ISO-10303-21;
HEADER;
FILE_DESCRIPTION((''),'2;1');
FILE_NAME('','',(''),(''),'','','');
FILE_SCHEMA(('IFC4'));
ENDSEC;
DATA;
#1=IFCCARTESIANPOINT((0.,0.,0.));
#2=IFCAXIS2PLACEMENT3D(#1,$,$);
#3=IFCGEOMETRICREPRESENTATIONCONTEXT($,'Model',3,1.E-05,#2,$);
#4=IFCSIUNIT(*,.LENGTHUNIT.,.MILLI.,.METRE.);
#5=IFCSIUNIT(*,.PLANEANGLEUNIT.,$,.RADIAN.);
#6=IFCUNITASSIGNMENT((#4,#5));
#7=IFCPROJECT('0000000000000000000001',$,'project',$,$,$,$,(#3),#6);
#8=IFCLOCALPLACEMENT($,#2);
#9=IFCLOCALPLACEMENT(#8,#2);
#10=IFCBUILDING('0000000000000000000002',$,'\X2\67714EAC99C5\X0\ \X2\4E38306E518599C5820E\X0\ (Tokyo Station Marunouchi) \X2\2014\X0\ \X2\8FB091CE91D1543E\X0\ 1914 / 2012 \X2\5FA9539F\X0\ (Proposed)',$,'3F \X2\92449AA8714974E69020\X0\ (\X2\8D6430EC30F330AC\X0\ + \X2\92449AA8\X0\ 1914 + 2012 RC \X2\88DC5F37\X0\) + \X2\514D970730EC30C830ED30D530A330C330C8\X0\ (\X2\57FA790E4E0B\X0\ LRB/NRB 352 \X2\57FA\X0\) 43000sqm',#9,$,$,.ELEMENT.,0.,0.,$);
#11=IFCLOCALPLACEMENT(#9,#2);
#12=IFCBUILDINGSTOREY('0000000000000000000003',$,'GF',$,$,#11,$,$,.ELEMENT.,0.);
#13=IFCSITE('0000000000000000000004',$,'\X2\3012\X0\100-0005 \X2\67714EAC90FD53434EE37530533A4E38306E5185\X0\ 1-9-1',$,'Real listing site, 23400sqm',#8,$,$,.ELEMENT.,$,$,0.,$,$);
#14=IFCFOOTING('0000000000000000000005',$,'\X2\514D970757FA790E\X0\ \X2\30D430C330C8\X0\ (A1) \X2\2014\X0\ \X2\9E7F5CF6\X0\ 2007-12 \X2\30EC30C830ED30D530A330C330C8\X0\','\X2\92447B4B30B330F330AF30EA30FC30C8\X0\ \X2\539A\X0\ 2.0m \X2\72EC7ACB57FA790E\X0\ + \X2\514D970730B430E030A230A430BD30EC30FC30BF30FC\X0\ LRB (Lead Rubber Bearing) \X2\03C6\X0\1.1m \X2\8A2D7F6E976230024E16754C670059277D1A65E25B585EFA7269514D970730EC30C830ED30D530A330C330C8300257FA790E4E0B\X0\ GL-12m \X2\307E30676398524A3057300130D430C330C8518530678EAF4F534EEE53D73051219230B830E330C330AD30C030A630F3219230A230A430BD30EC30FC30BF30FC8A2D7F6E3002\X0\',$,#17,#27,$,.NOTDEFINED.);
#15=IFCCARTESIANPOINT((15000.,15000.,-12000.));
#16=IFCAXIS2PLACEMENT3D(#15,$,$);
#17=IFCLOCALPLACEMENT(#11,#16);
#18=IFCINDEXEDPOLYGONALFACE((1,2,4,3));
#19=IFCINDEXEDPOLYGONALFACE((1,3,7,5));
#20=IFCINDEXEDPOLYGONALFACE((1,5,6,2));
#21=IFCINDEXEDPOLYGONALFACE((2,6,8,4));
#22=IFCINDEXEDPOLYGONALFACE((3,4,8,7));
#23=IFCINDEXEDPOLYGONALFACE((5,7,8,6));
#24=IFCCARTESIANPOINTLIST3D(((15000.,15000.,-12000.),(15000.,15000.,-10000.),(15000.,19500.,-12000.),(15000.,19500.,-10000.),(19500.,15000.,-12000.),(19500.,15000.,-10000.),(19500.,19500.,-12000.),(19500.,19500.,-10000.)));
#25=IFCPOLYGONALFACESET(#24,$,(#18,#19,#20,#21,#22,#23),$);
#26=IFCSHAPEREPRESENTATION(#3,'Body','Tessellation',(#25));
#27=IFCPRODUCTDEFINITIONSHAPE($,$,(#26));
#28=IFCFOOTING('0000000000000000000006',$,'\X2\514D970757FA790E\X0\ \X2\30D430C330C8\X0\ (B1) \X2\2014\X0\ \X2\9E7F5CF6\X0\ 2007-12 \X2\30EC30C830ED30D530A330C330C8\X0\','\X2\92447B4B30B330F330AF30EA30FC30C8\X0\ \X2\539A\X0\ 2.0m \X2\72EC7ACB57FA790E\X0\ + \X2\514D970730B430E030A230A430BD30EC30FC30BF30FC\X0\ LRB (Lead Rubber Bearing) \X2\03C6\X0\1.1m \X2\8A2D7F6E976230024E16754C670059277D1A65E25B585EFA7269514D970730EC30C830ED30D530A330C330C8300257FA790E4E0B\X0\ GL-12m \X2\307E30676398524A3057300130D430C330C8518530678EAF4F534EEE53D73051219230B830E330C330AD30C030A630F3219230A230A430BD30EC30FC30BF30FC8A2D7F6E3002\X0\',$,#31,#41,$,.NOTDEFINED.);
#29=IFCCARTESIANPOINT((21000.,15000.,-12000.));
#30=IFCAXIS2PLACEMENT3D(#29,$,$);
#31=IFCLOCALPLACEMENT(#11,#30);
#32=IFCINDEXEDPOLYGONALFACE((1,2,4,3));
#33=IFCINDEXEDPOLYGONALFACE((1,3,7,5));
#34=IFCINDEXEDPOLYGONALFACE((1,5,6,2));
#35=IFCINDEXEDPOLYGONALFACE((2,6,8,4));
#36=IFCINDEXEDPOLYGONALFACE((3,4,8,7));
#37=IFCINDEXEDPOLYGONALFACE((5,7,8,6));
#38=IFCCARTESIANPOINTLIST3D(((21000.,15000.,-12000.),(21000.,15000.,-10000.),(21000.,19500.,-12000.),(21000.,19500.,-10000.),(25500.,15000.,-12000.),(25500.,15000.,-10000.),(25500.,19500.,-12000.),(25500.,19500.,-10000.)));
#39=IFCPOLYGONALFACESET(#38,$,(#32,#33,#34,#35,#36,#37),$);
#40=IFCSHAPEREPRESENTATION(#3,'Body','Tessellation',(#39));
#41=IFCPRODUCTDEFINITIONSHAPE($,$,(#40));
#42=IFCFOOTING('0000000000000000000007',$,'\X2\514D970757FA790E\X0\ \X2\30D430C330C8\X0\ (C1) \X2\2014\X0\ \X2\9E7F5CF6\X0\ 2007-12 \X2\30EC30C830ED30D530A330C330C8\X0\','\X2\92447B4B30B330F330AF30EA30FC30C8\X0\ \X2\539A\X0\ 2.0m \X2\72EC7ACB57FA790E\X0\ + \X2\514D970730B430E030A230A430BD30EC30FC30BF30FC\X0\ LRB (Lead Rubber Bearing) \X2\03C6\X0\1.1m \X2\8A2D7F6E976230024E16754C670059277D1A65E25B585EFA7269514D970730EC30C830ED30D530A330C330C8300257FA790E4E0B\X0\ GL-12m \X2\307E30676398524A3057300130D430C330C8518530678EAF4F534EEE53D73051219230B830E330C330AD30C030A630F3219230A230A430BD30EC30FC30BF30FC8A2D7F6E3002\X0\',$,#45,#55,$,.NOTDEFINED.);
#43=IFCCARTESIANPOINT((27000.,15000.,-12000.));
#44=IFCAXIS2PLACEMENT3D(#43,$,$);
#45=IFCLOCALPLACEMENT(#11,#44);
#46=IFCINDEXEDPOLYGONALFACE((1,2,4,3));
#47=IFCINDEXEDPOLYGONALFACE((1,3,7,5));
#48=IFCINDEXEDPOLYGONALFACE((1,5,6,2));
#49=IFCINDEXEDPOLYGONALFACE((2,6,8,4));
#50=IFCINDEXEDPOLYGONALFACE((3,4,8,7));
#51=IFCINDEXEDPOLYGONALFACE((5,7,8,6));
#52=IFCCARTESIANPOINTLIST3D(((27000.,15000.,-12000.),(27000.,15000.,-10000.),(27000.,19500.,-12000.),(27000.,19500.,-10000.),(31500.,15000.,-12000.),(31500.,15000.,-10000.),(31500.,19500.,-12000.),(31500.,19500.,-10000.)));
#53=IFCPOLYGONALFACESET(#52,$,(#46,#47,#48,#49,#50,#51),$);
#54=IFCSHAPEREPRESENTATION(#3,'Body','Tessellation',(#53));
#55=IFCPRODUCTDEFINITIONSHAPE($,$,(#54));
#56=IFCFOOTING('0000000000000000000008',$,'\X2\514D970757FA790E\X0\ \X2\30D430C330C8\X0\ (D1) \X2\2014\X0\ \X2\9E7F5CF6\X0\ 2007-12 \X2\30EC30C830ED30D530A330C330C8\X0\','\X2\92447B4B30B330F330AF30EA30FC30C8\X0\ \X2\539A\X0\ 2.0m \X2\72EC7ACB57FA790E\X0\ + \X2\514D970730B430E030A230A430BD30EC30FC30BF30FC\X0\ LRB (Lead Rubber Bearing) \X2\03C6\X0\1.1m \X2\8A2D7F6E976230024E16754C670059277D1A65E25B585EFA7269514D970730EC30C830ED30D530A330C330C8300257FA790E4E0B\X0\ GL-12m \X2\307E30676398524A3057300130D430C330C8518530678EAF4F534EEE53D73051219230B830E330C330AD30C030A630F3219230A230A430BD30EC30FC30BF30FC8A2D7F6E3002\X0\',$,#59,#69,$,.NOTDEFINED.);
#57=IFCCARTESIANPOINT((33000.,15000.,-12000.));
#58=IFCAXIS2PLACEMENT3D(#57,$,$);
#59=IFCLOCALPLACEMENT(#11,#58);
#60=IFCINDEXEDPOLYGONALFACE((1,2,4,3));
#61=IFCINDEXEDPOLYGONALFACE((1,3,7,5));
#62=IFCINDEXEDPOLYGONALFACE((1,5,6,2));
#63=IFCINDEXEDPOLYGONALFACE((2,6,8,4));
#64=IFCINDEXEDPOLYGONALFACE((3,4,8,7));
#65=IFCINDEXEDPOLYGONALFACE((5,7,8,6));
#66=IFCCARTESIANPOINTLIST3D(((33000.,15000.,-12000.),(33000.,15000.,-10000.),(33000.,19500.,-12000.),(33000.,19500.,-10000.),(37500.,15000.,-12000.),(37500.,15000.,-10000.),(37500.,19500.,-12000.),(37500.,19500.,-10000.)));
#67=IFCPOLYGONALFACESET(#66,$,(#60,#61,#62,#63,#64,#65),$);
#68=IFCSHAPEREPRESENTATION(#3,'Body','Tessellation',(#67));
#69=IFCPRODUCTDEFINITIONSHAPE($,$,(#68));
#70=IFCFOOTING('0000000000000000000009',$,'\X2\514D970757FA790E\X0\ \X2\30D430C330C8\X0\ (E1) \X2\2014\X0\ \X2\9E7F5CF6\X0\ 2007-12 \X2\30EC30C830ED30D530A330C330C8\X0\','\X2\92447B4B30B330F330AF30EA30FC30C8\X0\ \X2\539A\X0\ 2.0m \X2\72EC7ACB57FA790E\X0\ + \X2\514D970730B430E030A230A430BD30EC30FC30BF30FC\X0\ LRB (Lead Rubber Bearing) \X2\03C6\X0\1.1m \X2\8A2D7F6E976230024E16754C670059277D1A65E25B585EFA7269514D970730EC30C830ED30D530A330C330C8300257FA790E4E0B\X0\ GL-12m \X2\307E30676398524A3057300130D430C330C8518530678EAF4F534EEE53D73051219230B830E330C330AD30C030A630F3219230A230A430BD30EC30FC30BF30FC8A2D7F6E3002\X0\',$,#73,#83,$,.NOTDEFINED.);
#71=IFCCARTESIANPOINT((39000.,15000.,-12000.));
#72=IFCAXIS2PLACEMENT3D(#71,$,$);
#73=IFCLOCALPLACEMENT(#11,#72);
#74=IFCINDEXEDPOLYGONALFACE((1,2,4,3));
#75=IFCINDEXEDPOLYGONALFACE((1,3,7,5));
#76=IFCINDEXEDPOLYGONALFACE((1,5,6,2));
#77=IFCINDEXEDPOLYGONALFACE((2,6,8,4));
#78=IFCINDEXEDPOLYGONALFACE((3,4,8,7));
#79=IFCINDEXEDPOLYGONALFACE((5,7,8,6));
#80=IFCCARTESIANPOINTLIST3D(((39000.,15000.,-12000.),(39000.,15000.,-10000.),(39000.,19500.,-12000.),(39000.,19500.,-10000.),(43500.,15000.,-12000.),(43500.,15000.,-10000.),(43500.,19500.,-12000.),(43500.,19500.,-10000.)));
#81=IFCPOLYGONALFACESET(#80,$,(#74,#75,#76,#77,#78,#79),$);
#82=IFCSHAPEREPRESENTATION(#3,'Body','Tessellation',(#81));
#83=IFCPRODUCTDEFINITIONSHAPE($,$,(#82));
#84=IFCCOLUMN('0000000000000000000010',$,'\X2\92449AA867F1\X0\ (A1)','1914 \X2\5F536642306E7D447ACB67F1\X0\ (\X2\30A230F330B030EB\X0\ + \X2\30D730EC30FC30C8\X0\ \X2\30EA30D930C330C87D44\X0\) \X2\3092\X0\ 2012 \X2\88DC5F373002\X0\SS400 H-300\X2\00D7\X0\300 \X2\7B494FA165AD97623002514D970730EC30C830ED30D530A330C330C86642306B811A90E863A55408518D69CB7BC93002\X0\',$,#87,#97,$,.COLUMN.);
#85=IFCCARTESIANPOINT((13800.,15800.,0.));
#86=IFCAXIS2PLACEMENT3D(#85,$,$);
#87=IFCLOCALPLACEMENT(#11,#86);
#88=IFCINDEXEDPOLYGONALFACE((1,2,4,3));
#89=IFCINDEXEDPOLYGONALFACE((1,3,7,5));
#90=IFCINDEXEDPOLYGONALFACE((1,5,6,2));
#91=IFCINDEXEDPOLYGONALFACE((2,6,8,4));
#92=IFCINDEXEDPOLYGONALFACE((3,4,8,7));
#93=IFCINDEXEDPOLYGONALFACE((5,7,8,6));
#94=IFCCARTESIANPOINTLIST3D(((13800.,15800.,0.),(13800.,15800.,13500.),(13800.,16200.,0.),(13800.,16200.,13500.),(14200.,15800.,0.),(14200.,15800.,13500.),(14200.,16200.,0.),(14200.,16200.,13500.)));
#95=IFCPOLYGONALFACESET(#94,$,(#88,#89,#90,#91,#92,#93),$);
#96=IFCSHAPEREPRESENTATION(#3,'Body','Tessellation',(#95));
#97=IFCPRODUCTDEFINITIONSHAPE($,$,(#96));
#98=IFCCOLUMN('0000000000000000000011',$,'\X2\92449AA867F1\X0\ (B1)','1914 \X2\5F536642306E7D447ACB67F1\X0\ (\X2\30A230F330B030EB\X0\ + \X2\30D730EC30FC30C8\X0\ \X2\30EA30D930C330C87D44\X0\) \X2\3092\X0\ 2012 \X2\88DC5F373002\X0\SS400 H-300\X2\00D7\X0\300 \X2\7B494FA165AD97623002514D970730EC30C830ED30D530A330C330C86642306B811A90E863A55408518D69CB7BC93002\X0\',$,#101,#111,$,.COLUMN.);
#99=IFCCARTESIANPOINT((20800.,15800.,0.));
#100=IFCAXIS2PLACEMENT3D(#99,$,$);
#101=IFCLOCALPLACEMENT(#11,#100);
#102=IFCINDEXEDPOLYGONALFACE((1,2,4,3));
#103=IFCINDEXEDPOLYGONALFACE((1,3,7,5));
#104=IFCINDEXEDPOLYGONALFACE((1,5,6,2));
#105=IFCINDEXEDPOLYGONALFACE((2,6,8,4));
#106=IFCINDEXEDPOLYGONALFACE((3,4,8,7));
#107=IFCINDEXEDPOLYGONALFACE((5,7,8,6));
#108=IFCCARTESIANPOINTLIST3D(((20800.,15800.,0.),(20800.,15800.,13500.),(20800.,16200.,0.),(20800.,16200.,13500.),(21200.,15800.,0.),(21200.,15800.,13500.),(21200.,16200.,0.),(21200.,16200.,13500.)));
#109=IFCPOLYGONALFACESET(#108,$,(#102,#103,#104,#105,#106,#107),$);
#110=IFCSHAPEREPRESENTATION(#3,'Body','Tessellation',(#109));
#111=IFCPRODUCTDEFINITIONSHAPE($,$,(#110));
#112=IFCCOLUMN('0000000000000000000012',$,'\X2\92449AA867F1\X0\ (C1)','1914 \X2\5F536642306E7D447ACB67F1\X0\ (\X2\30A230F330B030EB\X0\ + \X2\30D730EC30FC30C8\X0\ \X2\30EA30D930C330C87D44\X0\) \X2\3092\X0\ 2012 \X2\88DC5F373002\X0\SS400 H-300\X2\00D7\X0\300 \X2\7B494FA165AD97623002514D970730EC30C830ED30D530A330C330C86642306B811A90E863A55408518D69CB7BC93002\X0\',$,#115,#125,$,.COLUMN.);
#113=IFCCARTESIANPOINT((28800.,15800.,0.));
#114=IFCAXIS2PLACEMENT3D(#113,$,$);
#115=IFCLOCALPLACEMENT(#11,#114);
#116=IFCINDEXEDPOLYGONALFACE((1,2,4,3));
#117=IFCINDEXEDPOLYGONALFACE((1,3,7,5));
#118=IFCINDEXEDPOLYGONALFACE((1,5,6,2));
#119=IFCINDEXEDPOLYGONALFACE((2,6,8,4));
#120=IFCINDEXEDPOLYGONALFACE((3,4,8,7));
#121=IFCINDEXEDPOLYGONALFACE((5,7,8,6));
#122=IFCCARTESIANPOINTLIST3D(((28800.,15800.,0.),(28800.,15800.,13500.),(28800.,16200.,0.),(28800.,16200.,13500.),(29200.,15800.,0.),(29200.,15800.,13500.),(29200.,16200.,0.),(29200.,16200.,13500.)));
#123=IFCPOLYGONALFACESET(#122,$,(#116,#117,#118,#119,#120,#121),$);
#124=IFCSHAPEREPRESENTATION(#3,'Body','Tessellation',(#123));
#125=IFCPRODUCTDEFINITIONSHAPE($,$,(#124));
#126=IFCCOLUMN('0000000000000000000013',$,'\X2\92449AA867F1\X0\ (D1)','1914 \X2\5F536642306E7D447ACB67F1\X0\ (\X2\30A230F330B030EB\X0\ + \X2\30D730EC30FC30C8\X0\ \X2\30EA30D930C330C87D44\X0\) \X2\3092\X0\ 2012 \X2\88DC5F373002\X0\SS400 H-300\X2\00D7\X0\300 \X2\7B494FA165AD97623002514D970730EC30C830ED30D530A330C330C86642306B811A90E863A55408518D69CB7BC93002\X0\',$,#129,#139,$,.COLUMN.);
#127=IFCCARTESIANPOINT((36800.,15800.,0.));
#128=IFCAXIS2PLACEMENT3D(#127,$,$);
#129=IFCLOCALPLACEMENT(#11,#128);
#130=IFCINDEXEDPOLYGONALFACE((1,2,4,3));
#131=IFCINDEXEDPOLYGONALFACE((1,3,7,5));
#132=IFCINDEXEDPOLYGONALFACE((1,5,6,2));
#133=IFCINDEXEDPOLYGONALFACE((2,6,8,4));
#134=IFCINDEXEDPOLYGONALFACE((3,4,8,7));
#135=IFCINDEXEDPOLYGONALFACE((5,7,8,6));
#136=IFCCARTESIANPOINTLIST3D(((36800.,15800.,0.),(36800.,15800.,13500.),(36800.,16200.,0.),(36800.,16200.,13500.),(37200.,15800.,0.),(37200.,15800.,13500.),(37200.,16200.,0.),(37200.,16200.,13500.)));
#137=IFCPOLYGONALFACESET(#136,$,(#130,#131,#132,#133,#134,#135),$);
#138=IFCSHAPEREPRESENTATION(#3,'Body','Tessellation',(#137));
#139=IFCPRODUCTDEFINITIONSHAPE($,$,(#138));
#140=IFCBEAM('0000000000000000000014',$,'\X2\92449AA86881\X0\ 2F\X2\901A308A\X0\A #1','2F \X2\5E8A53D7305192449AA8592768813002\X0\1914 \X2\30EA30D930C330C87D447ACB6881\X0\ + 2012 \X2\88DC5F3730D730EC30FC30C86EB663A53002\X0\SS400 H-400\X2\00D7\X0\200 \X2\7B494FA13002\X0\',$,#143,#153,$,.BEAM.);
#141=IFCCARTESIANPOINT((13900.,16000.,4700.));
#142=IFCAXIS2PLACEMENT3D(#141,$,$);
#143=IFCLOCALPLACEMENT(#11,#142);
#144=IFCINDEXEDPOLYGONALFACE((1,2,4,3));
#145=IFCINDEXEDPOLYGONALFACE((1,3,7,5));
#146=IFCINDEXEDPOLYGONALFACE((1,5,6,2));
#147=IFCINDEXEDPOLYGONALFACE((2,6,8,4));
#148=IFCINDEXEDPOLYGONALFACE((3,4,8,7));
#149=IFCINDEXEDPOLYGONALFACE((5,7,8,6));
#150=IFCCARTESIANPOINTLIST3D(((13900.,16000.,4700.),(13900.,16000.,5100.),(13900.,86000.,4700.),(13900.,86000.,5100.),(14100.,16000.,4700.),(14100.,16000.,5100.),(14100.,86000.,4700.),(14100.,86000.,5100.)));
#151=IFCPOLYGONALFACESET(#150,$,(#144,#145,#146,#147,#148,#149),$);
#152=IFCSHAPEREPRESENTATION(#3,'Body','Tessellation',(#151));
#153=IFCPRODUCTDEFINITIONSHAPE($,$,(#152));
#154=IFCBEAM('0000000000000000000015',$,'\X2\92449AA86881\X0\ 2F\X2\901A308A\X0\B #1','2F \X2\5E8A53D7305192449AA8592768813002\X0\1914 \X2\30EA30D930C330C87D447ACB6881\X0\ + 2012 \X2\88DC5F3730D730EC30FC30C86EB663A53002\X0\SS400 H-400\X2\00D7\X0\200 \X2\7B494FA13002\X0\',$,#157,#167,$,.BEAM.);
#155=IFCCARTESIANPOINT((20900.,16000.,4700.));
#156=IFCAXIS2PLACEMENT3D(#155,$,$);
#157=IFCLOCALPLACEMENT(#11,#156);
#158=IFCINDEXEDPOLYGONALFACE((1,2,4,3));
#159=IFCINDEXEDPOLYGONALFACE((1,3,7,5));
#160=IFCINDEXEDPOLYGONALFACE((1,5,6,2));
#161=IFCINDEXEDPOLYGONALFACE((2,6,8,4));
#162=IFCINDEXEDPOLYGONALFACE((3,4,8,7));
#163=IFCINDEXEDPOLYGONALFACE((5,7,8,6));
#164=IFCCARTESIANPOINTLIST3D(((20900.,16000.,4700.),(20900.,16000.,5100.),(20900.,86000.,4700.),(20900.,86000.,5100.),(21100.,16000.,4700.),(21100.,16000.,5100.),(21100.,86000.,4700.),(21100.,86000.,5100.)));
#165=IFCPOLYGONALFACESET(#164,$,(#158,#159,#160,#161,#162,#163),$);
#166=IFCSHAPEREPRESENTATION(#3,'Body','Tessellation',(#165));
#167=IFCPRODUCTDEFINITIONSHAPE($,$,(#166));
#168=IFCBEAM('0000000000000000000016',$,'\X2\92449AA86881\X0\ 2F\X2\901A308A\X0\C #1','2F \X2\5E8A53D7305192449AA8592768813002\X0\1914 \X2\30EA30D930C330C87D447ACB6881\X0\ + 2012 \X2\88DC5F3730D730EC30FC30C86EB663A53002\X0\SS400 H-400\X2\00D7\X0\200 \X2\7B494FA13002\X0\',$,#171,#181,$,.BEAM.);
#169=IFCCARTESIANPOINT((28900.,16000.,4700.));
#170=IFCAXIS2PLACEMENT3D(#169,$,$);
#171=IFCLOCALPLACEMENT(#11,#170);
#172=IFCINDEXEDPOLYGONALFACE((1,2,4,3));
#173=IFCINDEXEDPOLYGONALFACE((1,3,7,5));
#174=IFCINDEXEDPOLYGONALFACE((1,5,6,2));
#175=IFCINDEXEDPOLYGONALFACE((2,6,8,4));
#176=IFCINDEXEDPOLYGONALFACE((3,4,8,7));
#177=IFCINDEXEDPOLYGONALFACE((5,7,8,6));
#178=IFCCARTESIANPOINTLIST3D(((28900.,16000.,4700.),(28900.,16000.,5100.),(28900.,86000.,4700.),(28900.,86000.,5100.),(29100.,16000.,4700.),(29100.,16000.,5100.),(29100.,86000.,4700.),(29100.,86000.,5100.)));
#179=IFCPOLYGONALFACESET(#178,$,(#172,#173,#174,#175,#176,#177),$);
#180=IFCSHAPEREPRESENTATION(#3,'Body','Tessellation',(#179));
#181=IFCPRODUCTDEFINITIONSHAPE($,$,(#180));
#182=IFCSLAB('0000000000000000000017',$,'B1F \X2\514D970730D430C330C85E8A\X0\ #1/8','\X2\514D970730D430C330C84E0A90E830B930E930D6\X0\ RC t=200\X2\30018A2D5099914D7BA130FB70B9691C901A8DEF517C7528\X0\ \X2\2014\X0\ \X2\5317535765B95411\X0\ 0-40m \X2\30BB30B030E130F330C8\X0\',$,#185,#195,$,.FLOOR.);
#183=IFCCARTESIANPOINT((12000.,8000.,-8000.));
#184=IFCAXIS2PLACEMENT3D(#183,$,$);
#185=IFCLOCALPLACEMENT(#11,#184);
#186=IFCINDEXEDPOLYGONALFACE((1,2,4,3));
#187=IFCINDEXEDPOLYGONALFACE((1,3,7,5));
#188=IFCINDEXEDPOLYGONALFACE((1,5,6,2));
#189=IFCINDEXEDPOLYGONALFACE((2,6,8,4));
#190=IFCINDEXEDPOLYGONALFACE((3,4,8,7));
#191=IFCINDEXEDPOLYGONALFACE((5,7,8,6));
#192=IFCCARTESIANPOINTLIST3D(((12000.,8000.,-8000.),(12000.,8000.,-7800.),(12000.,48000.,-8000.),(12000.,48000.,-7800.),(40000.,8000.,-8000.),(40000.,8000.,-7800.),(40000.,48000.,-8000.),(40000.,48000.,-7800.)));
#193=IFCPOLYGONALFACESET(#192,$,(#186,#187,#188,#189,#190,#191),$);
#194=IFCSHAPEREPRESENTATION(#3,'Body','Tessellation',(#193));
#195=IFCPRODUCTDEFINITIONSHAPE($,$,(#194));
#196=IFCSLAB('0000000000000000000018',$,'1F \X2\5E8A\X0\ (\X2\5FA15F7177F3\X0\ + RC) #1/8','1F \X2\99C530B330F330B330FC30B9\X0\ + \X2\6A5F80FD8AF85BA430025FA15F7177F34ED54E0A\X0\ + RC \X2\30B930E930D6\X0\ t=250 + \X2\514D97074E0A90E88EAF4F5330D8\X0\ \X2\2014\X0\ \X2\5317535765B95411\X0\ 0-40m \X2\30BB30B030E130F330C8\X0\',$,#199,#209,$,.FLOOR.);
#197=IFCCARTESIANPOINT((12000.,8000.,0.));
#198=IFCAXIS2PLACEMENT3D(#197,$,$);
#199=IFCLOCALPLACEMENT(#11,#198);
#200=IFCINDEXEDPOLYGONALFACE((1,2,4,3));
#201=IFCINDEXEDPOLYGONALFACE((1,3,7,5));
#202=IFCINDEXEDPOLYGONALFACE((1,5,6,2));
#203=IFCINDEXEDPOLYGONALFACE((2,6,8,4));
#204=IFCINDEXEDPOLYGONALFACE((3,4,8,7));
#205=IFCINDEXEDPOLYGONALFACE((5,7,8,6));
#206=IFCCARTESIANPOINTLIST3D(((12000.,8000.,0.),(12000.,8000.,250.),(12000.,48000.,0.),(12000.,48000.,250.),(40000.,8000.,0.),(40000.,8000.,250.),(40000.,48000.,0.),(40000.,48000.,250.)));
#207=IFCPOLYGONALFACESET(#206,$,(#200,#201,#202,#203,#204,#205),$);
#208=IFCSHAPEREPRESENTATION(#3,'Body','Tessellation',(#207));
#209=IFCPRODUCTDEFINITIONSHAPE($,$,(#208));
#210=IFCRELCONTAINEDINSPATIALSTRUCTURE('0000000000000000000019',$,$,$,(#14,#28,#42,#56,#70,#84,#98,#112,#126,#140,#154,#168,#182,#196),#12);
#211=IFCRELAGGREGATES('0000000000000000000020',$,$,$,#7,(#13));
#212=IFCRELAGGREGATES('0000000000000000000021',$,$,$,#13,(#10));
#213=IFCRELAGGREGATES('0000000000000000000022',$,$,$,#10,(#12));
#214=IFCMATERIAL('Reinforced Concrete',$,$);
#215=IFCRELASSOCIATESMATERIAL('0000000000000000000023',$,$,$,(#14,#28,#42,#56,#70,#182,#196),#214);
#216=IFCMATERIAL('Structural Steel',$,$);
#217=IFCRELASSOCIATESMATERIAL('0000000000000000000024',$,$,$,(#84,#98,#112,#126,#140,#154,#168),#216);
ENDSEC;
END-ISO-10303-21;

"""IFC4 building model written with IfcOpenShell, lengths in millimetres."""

from ifc_helpers import new_model, si_unit, frame, frame_2d, origin, place, context, project, spatial, rectangle, extrude, material, element, save


model = new_model("IFC4")

# Units and contexts
model_context = context("Model", 3, precision=1e-05, world=origin())
ifc_project = project(units=[si_unit("LENGTHUNIT", "METRE", prefix="MILLI"), si_unit("PLANEANGLEUNIT", "RADIAN")], contexts=[model_context])

# Site, building, storey
site_placement = place(None, origin())
site = spatial("IfcSite", under=ifc_project, at=site_placement, Name="〒100-0005 東京都千代田区丸の内 1-9-1", ObjectType="Real listing site, 23400sqm", CompositionType="ELEMENT", RefElevation=0.0)
building_placement = place(site_placement, origin())
building = spatial("IfcBuilding", under=site, at=building_placement, Name="東京駅 丸の内駅舎 (Tokyo Station Marunouchi) — 辰野金吾 1914 / 2012 復原 (Proposed)", ObjectType="3F 鉄骨煉瓦造 (赤レンガ + 鉄骨 1914 + 2012 RC 補強) + 免震レトロフィット (基礎下 LRB/NRB 352 基) 43000sqm", CompositionType="ELEMENT", ElevationOfRefHeight=0.0, ElevationOfTerrain=0.0)
storey_placement = place(building_placement, origin())
storey = spatial("IfcBuildingStorey", under=building, at=storey_placement, Name="GF", CompositionType="ELEMENT", Elevation=0.0)

# Footings
ifc_material_1 = material(Name="Reinforced Concrete")
footing_1_placement = place(storey_placement, frame((15000.0, 15000.0, -12000.0)))
element("IfcFooting", 1, at=footing_1_placement, inside=storey, material=ifc_material_1, Name="免震基礎 ピット (A1) — 鹿島 2007-12 レトロフィット", Description="鉄筋コンクリート 厚 2.0m 独立基礎 + 免震ゴムアイソレーター LRB (Lead Rubber Bearing) φ1.1m 設置面。世界最大級既存建物免震レトロフィット。基礎下 GL-12m まで掘削し、ピット内で躯体仮受け→ジャッキダウン→アイソレーター設置。", PredefinedType="NOTDEFINED", context=model_context, shape_type="SweptSolid", body=[
    extrude(rectangle(XDim=4500.0, YDim=4500.0, at=frame_2d((2250.0, 2250.0))), frame((15000.0, 15000.0, -12000.0)), (0.0, 0.0, 1.0), 2000.0),
])
footing_2_placement = place(storey_placement, frame((21000.0, 15000.0, -12000.0)))
element("IfcFooting", 2, at=footing_2_placement, inside=storey, material=ifc_material_1, Name="免震基礎 ピット (B1) — 鹿島 2007-12 レトロフィット", Description="鉄筋コンクリート 厚 2.0m 独立基礎 + 免震ゴムアイソレーター LRB (Lead Rubber Bearing) φ1.1m 設置面。世界最大級既存建物免震レトロフィット。基礎下 GL-12m まで掘削し、ピット内で躯体仮受け→ジャッキダウン→アイソレーター設置。", PredefinedType="NOTDEFINED", context=model_context, shape_type="SweptSolid", body=[
    extrude(rectangle(XDim=4500.0, YDim=4500.0, at=frame_2d((2250.0, 2250.0))), frame((21000.0, 15000.0, -12000.0)), (0.0, 0.0, 1.0), 2000.0),
])
footing_3_placement = place(storey_placement, frame((27000.0, 15000.0, -12000.0)))
element("IfcFooting", 3, at=footing_3_placement, inside=storey, material=ifc_material_1, Name="免震基礎 ピット (C1) — 鹿島 2007-12 レトロフィット", Description="鉄筋コンクリート 厚 2.0m 独立基礎 + 免震ゴムアイソレーター LRB (Lead Rubber Bearing) φ1.1m 設置面。世界最大級既存建物免震レトロフィット。基礎下 GL-12m まで掘削し、ピット内で躯体仮受け→ジャッキダウン→アイソレーター設置。", PredefinedType="NOTDEFINED", context=model_context, shape_type="SweptSolid", body=[
    extrude(rectangle(XDim=4500.0, YDim=4500.0, at=frame_2d((2250.0, 2250.0))), frame((27000.0, 15000.0, -12000.0)), (0.0, 0.0, 1.0), 2000.0),
])
footing_4_placement = place(storey_placement, frame((33000.0, 15000.0, -12000.0)))
element("IfcFooting", 4, at=footing_4_placement, inside=storey, material=ifc_material_1, Name="免震基礎 ピット (D1) — 鹿島 2007-12 レトロフィット", Description="鉄筋コンクリート 厚 2.0m 独立基礎 + 免震ゴムアイソレーター LRB (Lead Rubber Bearing) φ1.1m 設置面。世界最大級既存建物免震レトロフィット。基礎下 GL-12m まで掘削し、ピット内で躯体仮受け→ジャッキダウン→アイソレーター設置。", PredefinedType="NOTDEFINED", context=model_context, shape_type="SweptSolid", body=[
    extrude(rectangle(XDim=4500.0, YDim=4500.0, at=frame_2d((2250.0, 2250.0))), frame((33000.0, 15000.0, -12000.0)), (0.0, 0.0, 1.0), 2000.0),
])
footing_5_placement = place(storey_placement, frame((39000.0, 15000.0, -12000.0)))
element("IfcFooting", 5, at=footing_5_placement, inside=storey, material=ifc_material_1, Name="免震基礎 ピット (E1) — 鹿島 2007-12 レトロフィット", Description="鉄筋コンクリート 厚 2.0m 独立基礎 + 免震ゴムアイソレーター LRB (Lead Rubber Bearing) φ1.1m 設置面。世界最大級既存建物免震レトロフィット。基礎下 GL-12m まで掘削し、ピット内で躯体仮受け→ジャッキダウン→アイソレーター設置。", PredefinedType="NOTDEFINED", context=model_context, shape_type="SweptSolid", body=[
    extrude(rectangle(XDim=4500.0, YDim=4500.0, at=frame_2d((2250.0, 2250.0))), frame((39000.0, 15000.0, -12000.0)), (0.0, 0.0, 1.0), 2000.0),
])

# Columns
ifc_material_2 = material(Name="Structural Steel")
column_1_placement = place(storey_placement, frame((13800.0, 15800.0, 0.0)))
element("IfcColumn", 6, at=column_1_placement, inside=storey, material=ifc_material_2, Name="鉄骨柱 (A1)", Description="1914 当時の組立柱 (アングル + プレート リベット組) を 2012 補強。SS400 H-300×300 等価断面。免震レトロフィット時に脚部接合再構築。", PredefinedType="COLUMN", context=model_context, shape_type="SweptSolid", body=[
    extrude(rectangle(XDim=400.0, YDim=400.0, at=frame_2d((200.0, 200.0))), frame((13800.0, 15800.0, 0.0)), (0.0, 0.0, 1.0), 13500.0),
])
column_2_placement = place(storey_placement, frame((20800.0, 15800.0, 0.0)))
element("IfcColumn", 7, at=column_2_placement, inside=storey, material=ifc_material_2, Name="鉄骨柱 (B1)", Description="1914 当時の組立柱 (アングル + プレート リベット組) を 2012 補強。SS400 H-300×300 等価断面。免震レトロフィット時に脚部接合再構築。", PredefinedType="COLUMN", context=model_context, shape_type="SweptSolid", body=[
    extrude(rectangle(XDim=400.0, YDim=400.0, at=frame_2d((200.0, 200.0))), frame((20800.0, 15800.0, 0.0)), (0.0, 0.0, 1.0), 13500.0),
])
column_3_placement = place(storey_placement, frame((28800.0, 15800.0, 0.0)))
element("IfcColumn", 8, at=column_3_placement, inside=storey, material=ifc_material_2, Name="鉄骨柱 (C1)", Description="1914 当時の組立柱 (アングル + プレート リベット組) を 2012 補強。SS400 H-300×300 等価断面。免震レトロフィット時に脚部接合再構築。", PredefinedType="COLUMN", context=model_context, shape_type="SweptSolid", body=[
    extrude(rectangle(XDim=400.0, YDim=400.0, at=frame_2d((200.0, 200.0))), frame((28800.0, 15800.0, 0.0)), (0.0, 0.0, 1.0), 13500.0),
])
column_4_placement = place(storey_placement, frame((36800.0, 15800.0, 0.0)))
element("IfcColumn", 9, at=column_4_placement, inside=storey, material=ifc_material_2, Name="鉄骨柱 (D1)", Description="1914 当時の組立柱 (アングル + プレート リベット組) を 2012 補強。SS400 H-300×300 等価断面。免震レトロフィット時に脚部接合再構築。", PredefinedType="COLUMN", context=model_context, shape_type="SweptSolid", body=[
    extrude(rectangle(XDim=400.0, YDim=400.0, at=frame_2d((200.0, 200.0))), frame((36800.0, 15800.0, 0.0)), (0.0, 0.0, 1.0), 13500.0),
])

# Beams
beam_1_placement = place(storey_placement, frame((13900.0, 16000.0, 4700.0)))
element("IfcBeam", 10, at=beam_1_placement, inside=storey, material=ifc_material_2, Name="鉄骨梁 2F通りA #1", Description="2F 床受け鉄骨大梁。1914 リベット組立梁 + 2012 補強プレート溶接。SS400 H-400×200 等価。", PredefinedType="BEAM", context=model_context, shape_type="SweptSolid", body=[
    extrude(rectangle(XDim=200.0, YDim=70000.0, at=frame_2d((100.0, 35000.0))), frame((13900.0, 16000.0, 4700.0)), (0.0, 0.0, 1.0), 400.0),
])
beam_2_placement = place(storey_placement, frame((20900.0, 16000.0, 4700.0)))
element("IfcBeam", 11, at=beam_2_placement, inside=storey, material=ifc_material_2, Name="鉄骨梁 2F通りB #1", Description="2F 床受け鉄骨大梁。1914 リベット組立梁 + 2012 補強プレート溶接。SS400 H-400×200 等価。", PredefinedType="BEAM", context=model_context, shape_type="SweptSolid", body=[
    extrude(rectangle(XDim=200.0, YDim=70000.0, at=frame_2d((100.0, 35000.0))), frame((20900.0, 16000.0, 4700.0)), (0.0, 0.0, 1.0), 400.0),
])
beam_3_placement = place(storey_placement, frame((28900.0, 16000.0, 4700.0)))
element("IfcBeam", 12, at=beam_3_placement, inside=storey, material=ifc_material_2, Name="鉄骨梁 2F通りC #1", Description="2F 床受け鉄骨大梁。1914 リベット組立梁 + 2012 補強プレート溶接。SS400 H-400×200 等価。", PredefinedType="BEAM", context=model_context, shape_type="SweptSolid", body=[
    extrude(rectangle(XDim=200.0, YDim=70000.0, at=frame_2d((100.0, 35000.0))), frame((28900.0, 16000.0, 4700.0)), (0.0, 0.0, 1.0), 400.0),
])

# Slabs
slab_1_placement = place(storey_placement, frame((12000.0, 8000.0, -8000.0)))
element("IfcSlab", 13, at=slab_1_placement, inside=storey, material=ifc_material_1, Name="B1F 免震ピット床 #1/8", Description="免震ピット上部スラブ RC t=200、設備配管・点検通路兼用 — 北南方向 0-40m セグメント", PredefinedType="FLOOR", context=model_context, shape_type="SweptSolid", body=[
    extrude(rectangle(XDim=28000.0, YDim=40000.0, at=frame_2d((14000.0, 20000.0))), frame((12000.0, 8000.0, -8000.0)), (0.0, 0.0, 1.0), 200.0),
])
slab_2_placement = place(storey_placement, frame((12000.0, 8000.0, 0.0)))
element("IfcSlab", 14, at=slab_2_placement, inside=storey, material=ifc_material_1, Name="1F 床 (御影石 + RC) #1/8", Description="1F 駅コンコース + 機能諸室。御影石仕上 + RC スラブ t=250 + 免震上部躯体ヘ — 北南方向 0-40m セグメント", PredefinedType="FLOOR", context=model_context, shape_type="SweptSolid", body=[
    extrude(rectangle(XDim=28000.0, YDim=40000.0, at=frame_2d((14000.0, 20000.0))), frame((12000.0, 8000.0, 0.0)), (0.0, 0.0, 1.0), 250.0),
])

save(model, "model.ifc")
